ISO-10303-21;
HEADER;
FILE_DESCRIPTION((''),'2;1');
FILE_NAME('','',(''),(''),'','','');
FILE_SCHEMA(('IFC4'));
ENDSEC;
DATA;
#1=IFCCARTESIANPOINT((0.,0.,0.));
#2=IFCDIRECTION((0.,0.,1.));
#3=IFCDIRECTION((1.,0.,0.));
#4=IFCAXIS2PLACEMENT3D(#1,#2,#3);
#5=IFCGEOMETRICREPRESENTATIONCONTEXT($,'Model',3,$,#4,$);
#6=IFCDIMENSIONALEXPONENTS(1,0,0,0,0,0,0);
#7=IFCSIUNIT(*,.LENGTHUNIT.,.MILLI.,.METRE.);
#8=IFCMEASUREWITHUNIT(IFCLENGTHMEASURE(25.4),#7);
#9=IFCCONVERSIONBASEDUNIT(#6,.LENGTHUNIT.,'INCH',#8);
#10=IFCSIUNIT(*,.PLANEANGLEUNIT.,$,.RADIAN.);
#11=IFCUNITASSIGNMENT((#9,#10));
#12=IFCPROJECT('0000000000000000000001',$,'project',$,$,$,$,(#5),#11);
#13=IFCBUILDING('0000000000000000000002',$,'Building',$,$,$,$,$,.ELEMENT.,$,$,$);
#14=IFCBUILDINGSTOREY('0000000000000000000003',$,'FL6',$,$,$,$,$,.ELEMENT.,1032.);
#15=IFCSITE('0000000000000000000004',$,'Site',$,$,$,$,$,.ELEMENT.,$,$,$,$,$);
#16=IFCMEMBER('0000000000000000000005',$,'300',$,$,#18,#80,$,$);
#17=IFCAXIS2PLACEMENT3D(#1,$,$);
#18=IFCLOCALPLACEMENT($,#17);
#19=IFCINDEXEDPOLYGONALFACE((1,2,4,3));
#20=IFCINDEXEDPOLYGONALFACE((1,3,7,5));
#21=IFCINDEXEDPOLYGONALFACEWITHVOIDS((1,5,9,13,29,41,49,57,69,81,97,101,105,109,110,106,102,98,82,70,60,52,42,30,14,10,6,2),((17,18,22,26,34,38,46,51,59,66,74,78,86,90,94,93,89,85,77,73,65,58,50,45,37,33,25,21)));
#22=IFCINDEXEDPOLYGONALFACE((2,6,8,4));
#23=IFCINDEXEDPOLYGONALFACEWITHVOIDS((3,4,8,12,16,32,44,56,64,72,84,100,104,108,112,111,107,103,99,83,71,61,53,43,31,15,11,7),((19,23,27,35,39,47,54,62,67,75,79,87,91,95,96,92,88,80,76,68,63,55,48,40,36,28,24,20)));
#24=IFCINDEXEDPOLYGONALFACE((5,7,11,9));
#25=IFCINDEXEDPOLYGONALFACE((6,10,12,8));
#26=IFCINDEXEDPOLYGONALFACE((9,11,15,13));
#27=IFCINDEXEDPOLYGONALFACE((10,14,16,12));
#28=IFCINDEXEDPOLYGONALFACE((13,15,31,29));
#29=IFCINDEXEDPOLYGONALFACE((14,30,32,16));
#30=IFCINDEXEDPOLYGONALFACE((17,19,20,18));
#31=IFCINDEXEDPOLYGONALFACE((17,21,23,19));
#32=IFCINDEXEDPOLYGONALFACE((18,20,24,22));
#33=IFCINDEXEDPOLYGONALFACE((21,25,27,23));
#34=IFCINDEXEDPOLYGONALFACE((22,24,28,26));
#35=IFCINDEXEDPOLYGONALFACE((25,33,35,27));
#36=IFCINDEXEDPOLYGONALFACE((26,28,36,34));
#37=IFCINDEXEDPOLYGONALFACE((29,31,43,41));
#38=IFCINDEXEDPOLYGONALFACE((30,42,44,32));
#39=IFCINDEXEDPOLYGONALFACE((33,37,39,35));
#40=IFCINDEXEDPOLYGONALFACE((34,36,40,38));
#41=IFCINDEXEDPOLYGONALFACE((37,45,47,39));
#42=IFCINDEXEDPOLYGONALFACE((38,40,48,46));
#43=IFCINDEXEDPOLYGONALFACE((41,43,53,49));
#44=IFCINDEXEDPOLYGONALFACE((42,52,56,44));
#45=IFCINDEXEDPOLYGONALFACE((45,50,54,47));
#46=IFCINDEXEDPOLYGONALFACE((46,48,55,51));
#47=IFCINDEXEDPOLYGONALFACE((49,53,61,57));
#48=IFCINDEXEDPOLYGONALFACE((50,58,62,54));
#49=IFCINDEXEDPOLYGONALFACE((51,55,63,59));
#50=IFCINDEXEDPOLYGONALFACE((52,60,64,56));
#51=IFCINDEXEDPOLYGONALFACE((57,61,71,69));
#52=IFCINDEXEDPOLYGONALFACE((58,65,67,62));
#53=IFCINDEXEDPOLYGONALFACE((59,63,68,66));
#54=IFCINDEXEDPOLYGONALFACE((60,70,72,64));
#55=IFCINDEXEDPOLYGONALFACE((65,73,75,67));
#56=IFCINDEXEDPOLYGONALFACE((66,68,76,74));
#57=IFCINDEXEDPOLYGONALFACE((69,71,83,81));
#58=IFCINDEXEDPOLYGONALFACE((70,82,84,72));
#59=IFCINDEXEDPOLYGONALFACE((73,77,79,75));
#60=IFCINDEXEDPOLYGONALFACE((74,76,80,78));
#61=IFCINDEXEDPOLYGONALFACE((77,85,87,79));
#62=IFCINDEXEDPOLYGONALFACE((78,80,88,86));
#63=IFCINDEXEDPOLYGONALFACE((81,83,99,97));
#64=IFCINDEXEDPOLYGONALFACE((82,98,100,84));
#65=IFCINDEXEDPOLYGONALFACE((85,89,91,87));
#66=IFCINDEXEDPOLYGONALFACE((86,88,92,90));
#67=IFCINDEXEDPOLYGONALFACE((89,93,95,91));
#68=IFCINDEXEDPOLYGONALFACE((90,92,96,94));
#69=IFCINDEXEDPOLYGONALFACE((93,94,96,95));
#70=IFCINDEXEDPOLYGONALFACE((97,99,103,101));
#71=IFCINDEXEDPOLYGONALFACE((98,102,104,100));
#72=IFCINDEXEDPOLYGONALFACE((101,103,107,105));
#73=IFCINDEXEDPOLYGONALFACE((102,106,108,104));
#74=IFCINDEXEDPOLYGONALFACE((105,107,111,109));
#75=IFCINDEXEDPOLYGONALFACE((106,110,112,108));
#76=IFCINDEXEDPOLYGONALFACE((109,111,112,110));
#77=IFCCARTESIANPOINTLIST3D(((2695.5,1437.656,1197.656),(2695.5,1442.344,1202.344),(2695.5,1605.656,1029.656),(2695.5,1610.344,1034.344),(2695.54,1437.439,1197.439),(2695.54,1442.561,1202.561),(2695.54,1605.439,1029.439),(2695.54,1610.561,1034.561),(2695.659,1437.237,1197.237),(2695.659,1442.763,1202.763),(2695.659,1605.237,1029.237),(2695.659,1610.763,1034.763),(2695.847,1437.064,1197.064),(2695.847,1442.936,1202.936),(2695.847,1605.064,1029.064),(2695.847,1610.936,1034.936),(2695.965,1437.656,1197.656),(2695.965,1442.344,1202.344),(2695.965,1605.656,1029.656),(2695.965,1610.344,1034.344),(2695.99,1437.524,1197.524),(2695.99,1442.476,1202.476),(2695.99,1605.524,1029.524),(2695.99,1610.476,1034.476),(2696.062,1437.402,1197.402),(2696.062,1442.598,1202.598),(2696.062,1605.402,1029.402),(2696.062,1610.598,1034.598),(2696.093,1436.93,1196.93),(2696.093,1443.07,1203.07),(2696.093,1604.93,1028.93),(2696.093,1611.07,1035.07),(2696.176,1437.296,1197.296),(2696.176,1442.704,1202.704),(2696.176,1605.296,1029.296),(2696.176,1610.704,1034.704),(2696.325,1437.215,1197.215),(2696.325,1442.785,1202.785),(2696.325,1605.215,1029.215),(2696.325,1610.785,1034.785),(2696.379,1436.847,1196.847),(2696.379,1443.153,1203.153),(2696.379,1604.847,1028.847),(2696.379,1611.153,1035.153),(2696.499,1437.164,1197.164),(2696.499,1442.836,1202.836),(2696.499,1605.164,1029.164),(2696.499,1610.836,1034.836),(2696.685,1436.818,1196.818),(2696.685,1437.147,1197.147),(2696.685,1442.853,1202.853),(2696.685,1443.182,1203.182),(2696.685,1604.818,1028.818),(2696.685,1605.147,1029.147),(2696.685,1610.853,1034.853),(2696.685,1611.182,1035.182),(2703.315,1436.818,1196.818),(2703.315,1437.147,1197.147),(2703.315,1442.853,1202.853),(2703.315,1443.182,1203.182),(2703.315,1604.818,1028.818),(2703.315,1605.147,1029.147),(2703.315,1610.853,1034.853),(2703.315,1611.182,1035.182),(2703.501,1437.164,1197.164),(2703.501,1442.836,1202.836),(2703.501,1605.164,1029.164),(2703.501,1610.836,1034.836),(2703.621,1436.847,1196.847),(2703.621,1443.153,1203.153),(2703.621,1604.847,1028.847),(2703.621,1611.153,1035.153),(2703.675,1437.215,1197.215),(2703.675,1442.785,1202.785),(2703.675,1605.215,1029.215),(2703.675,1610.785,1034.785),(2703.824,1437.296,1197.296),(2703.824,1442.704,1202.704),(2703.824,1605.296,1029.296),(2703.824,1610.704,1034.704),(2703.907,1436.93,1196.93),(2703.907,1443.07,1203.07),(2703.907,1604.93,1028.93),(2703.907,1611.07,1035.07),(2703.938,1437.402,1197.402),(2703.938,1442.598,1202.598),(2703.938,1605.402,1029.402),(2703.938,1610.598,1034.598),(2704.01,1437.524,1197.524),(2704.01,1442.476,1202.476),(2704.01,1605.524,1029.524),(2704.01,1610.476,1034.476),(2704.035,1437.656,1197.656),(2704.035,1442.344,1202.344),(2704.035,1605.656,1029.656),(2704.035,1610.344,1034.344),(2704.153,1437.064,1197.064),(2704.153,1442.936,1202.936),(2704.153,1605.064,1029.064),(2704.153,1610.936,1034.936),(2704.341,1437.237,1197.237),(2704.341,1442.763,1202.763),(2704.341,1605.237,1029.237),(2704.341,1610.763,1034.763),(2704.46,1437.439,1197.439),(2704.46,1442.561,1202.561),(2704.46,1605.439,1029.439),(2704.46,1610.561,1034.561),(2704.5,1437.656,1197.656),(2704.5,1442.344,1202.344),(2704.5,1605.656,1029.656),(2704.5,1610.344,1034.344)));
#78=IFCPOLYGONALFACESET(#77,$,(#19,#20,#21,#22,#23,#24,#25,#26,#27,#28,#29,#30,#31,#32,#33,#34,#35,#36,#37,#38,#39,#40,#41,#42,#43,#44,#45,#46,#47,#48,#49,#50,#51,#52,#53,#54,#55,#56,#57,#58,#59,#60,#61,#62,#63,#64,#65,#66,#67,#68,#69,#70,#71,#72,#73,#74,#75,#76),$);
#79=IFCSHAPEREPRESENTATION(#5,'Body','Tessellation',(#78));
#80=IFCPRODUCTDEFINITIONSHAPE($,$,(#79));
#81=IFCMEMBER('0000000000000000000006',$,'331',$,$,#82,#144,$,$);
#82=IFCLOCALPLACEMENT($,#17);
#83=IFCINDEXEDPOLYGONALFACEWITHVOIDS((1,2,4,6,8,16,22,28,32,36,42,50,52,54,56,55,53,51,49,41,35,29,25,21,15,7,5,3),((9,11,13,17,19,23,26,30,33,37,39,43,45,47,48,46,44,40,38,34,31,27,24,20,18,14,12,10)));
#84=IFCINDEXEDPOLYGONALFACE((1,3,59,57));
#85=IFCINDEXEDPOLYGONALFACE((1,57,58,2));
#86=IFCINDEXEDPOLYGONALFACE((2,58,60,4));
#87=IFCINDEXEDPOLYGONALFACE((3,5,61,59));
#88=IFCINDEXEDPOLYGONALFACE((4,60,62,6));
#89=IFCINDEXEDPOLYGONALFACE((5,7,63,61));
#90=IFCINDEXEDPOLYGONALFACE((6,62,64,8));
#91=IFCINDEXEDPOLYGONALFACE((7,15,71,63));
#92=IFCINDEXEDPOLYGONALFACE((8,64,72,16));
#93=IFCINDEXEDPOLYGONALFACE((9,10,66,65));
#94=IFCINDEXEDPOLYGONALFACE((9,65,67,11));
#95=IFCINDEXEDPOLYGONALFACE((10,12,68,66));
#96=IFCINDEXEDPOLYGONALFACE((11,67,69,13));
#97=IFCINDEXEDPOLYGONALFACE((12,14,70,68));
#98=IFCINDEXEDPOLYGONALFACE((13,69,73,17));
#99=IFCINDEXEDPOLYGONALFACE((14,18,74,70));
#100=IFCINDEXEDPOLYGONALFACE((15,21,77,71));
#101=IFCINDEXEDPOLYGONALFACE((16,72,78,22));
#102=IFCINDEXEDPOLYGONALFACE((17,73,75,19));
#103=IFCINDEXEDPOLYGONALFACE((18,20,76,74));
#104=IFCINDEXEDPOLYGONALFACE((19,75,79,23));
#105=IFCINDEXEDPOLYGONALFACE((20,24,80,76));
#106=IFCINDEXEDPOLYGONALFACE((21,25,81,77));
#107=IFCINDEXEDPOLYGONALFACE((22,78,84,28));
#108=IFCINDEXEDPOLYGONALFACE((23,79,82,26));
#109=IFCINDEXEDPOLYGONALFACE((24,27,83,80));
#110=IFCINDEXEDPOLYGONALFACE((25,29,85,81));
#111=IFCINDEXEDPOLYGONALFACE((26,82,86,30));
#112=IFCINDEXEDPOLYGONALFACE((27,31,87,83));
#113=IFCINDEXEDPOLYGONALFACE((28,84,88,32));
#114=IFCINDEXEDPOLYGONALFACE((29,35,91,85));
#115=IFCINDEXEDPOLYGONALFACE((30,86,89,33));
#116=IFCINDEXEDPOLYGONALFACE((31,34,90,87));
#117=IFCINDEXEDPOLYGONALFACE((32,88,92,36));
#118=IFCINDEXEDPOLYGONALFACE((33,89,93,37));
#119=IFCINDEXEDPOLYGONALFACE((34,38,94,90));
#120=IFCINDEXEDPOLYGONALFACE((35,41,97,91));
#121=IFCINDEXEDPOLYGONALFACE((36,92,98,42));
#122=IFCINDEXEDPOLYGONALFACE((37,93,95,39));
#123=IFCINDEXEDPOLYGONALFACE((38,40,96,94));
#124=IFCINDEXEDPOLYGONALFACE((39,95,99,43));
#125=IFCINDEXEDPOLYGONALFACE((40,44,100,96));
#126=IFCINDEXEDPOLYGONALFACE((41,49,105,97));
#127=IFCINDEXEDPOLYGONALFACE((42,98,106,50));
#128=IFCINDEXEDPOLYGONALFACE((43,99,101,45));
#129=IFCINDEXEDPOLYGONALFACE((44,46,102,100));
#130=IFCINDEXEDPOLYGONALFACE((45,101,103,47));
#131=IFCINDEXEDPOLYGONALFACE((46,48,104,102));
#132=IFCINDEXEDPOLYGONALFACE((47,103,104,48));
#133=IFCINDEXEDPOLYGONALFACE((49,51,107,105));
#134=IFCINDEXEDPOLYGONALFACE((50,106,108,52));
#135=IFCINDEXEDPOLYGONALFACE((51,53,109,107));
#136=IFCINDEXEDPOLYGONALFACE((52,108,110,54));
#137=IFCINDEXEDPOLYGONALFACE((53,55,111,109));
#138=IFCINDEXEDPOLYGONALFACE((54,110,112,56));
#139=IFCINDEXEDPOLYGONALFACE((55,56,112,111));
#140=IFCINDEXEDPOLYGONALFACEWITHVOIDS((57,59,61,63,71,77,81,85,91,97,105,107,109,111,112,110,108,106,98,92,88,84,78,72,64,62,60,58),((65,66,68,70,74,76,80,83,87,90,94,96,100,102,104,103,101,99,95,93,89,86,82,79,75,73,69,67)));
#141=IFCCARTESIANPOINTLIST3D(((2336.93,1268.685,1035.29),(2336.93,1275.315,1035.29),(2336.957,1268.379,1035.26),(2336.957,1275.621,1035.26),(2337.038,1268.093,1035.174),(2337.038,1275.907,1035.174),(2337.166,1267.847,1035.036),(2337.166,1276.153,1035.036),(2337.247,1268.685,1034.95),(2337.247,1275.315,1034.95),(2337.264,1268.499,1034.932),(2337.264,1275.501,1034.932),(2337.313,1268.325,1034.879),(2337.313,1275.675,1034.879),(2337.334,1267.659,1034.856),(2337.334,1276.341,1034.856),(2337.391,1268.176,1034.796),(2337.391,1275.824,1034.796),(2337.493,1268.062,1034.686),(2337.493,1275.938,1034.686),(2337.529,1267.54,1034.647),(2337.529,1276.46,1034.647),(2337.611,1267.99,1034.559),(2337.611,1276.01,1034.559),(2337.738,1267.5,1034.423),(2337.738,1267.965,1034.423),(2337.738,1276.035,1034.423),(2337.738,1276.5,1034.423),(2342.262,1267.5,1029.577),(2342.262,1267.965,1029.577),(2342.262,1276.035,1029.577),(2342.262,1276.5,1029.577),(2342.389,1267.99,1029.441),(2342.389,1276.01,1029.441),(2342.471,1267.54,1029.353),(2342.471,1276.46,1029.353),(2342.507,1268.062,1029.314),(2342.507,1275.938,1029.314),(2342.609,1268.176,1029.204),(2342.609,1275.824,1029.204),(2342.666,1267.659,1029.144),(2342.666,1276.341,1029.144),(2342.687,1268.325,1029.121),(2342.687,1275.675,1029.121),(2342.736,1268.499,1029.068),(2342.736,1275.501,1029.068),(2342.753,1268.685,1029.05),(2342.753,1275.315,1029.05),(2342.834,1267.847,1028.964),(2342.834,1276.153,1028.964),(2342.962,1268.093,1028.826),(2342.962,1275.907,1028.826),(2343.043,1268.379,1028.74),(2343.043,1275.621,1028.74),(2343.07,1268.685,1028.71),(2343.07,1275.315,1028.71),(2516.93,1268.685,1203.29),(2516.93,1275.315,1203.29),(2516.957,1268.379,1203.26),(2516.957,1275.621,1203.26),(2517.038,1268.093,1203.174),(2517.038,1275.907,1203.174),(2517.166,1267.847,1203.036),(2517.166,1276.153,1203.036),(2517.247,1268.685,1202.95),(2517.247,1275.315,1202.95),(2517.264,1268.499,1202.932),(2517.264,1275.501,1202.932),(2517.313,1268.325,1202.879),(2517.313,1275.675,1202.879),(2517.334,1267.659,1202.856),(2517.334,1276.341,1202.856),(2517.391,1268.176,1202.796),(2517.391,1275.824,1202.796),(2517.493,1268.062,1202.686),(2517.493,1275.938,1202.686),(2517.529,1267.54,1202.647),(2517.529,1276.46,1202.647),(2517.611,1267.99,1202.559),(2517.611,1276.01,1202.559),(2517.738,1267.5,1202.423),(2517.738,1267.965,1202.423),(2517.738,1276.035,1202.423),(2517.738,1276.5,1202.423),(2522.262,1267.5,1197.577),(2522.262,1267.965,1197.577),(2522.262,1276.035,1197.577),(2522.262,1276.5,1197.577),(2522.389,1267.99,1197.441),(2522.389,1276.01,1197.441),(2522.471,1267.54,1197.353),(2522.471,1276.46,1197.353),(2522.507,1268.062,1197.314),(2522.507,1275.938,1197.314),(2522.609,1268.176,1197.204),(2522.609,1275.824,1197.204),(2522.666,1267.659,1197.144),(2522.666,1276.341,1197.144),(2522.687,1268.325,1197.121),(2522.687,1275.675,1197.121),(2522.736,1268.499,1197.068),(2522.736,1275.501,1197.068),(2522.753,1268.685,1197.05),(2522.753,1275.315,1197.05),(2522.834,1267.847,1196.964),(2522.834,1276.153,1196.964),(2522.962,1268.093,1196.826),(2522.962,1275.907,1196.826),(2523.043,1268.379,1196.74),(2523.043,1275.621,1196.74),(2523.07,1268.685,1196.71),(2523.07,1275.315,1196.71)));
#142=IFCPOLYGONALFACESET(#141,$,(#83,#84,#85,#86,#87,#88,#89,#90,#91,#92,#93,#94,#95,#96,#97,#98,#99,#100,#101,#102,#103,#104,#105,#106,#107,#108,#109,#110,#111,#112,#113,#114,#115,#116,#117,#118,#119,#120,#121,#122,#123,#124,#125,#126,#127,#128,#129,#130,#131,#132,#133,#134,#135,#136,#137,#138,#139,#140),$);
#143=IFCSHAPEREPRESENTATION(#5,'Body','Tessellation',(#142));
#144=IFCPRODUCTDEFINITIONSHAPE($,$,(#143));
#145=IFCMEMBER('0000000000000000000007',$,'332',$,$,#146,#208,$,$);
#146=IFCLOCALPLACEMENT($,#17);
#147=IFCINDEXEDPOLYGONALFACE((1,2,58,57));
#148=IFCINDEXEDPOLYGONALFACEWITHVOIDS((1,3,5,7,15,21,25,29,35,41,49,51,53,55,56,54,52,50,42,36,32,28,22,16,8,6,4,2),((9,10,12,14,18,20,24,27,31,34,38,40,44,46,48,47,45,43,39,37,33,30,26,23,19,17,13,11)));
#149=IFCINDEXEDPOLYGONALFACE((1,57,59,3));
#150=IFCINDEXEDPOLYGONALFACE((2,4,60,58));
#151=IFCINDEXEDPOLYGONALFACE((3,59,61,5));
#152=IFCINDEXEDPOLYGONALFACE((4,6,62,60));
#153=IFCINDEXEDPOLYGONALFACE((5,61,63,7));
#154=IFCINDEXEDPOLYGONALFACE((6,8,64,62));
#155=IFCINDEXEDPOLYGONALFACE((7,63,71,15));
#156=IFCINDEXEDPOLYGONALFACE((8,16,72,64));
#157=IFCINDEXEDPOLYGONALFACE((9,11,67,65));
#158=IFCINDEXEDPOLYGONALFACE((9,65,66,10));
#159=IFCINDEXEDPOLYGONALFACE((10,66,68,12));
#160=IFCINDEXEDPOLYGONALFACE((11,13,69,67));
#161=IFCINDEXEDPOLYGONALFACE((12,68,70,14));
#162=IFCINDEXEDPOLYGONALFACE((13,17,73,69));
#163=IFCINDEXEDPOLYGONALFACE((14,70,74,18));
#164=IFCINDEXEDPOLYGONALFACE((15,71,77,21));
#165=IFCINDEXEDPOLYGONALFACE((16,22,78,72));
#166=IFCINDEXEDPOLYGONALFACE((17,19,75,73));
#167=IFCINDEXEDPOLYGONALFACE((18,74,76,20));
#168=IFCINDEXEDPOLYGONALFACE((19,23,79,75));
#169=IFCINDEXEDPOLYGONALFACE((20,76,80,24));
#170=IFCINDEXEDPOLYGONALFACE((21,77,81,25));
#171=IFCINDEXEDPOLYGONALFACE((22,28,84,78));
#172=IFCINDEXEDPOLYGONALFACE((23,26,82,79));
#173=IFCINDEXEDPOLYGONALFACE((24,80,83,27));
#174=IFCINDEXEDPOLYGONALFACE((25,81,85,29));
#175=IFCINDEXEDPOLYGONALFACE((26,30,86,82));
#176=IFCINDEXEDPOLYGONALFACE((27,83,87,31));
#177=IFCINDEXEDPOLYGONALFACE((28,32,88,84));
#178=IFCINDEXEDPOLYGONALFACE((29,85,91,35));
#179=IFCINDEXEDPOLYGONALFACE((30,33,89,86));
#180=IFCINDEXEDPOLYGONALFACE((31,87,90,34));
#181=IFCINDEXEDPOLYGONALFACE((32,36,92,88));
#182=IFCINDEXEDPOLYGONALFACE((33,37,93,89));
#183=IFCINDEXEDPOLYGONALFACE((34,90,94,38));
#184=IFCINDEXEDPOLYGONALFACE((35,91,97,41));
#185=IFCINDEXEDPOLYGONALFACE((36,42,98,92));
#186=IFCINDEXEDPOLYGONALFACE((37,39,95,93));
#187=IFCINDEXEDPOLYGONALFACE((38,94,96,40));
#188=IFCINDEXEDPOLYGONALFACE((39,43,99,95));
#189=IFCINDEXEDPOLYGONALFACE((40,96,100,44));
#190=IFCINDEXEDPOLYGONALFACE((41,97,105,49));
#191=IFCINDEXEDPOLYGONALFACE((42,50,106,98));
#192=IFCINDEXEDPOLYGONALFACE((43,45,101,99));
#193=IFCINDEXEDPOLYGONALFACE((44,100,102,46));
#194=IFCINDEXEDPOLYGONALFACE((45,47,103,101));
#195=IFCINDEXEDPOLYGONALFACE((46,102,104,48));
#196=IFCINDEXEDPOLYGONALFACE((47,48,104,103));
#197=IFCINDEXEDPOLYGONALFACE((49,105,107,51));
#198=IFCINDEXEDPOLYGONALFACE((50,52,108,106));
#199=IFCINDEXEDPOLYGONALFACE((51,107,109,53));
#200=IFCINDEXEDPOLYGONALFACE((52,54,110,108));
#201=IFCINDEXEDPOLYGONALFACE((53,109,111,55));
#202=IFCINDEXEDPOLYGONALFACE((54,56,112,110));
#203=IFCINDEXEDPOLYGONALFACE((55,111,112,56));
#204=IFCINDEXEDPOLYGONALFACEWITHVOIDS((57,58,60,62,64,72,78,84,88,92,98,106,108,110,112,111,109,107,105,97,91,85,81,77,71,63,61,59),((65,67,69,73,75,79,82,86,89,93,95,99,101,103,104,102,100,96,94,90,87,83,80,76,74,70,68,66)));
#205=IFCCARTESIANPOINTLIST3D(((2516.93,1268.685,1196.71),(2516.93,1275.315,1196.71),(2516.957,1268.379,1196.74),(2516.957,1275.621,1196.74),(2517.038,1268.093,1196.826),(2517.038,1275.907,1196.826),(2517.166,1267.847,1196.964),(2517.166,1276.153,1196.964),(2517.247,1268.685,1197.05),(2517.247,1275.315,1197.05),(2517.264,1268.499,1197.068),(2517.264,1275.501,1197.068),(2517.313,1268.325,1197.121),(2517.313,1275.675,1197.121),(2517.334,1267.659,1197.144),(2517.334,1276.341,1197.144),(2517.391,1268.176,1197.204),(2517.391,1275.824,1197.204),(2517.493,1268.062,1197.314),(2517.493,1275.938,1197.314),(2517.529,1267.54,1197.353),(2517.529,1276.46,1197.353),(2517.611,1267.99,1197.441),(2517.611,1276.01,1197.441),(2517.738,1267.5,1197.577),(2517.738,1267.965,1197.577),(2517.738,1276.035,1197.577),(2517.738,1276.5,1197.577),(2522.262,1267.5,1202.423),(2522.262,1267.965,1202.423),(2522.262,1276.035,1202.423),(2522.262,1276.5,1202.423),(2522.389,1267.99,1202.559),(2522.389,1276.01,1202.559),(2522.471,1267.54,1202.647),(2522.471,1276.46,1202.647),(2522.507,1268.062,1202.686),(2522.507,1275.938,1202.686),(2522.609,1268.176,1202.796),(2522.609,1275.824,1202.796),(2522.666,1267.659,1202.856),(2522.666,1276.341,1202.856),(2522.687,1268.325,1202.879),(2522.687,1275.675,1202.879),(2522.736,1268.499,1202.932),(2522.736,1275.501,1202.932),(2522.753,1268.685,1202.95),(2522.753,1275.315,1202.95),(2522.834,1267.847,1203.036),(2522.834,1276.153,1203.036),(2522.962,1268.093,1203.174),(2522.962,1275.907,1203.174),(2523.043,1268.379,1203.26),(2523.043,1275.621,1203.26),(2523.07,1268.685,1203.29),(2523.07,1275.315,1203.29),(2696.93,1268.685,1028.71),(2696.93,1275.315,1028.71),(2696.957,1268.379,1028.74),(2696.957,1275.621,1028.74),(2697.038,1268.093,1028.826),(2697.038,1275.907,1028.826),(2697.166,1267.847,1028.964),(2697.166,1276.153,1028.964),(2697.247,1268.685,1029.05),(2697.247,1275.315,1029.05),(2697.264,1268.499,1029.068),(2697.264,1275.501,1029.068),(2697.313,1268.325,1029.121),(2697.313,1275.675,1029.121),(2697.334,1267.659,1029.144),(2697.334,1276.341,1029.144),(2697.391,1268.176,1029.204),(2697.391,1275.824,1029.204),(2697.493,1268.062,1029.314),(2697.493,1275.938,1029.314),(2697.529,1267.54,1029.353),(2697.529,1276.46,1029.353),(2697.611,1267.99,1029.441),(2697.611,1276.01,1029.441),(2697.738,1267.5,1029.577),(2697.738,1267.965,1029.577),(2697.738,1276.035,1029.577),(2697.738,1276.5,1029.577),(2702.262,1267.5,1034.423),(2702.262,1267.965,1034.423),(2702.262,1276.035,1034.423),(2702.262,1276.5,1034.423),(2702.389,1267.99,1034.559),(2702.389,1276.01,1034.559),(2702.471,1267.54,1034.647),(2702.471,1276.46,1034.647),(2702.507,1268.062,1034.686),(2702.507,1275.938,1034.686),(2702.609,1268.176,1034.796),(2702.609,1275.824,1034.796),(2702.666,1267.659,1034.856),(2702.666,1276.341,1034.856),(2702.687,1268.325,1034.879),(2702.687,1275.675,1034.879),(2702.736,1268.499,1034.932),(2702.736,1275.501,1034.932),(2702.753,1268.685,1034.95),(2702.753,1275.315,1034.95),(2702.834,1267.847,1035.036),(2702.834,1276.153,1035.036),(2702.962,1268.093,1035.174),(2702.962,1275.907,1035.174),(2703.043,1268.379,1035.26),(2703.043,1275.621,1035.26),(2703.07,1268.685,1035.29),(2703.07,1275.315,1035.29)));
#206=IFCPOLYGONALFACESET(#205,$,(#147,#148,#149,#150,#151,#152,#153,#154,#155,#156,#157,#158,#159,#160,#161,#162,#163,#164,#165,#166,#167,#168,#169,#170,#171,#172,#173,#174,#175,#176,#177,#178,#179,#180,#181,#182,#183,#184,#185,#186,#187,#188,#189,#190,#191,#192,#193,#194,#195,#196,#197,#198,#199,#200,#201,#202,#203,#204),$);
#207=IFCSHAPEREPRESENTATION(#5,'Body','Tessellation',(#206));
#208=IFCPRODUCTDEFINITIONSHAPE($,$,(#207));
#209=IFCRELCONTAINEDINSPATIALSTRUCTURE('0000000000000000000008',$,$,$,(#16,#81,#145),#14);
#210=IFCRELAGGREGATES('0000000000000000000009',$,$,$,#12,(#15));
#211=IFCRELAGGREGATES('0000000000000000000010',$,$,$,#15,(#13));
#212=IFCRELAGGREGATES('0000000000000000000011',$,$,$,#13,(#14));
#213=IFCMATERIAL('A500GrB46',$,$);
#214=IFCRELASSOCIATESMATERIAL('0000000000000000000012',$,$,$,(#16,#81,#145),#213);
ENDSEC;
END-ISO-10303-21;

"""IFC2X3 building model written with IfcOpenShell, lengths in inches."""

from ifc_helpers import new_model, entity, si_unit, converted_unit, frame, origin_with_axes, origin_2d_with_axis, place, context, project, spatial, hollow_rectangle, extrude, material, element, save


model = new_model("IFC2X3")

# Units and contexts
model_context = context("Model", 3, world=origin_with_axes())
ifc_project = project(units=[converted_unit("LENGTHUNIT", "INCH", entity("IfcLengthMeasure", 25.4), si_unit("LENGTHUNIT", "METRE", prefix="MILLI"), dimensions=[1, 0, 0, 0, 0, 0, 0]), si_unit("PLANEANGLEUNIT", "RADIAN")], contexts=[model_context])

# Site, building, storey
site = spatial("IfcSite", under=ifc_project, Name="Site", CompositionType="ELEMENT")
building = spatial("IfcBuilding", under=site, Name="Building", CompositionType="ELEMENT")
storey = spatial("IfcBuildingStorey", under=building, Name="FL6", CompositionType="ELEMENT", Elevation=1032.0)

# Members
ifc_material_1 = material(Name="A500GrB46")
for number, where, z_axis, x_axis, name in (
    (1, (2700.0, 1608.0, 1032.0), (0.0, -0.707107, 0.707107), (1.0, 0.0, 0.0), "300"),
):
    element("IfcMember", number, at=place(None, frame(where, z_axis=z_axis, x_axis=x_axis)), inside=storey, material=ifc_material_1, Name=name, context=model_context, shape_type="SweptSolid", body=[
        extrude(hollow_rectangle(XDim=9.0, YDim=9.0, WallThickness=0.465, InnerFilletRadius=0.72, OuterFilletRadius=1.185, at=origin_2d_with_axis()), origin_with_axes(), (0.0, 0.0, 1.0), 237.588),
    ])
for number, where, z_axis, x_axis, name in (
    (2, (2340.0, 1272.0, 1032.0), (0.731055, 0.0, 0.682318), (0.0, 1.0, 0.0), "331"),
    (3, (2700.0, 1272.0, 1032.0), (-0.731055, 0.0, 0.682318), (0.0, -1.0, 0.0), "332"),
):
    element("IfcMember", number, at=place(None, frame(where, z_axis=z_axis, x_axis=x_axis)), inside=storey, material=ifc_material_1, Name=name, context=model_context, shape_type="SweptSolid", body=[
        extrude(hollow_rectangle(XDim=9.0, YDim=9.0, WallThickness=0.465, InnerFilletRadius=0.72, OuterFilletRadius=1.185, at=origin_2d_with_axis()), origin_with_axes(), (0.0, 0.0, 1.0), 246.219),
    ])

save(model, "model.ifc")
